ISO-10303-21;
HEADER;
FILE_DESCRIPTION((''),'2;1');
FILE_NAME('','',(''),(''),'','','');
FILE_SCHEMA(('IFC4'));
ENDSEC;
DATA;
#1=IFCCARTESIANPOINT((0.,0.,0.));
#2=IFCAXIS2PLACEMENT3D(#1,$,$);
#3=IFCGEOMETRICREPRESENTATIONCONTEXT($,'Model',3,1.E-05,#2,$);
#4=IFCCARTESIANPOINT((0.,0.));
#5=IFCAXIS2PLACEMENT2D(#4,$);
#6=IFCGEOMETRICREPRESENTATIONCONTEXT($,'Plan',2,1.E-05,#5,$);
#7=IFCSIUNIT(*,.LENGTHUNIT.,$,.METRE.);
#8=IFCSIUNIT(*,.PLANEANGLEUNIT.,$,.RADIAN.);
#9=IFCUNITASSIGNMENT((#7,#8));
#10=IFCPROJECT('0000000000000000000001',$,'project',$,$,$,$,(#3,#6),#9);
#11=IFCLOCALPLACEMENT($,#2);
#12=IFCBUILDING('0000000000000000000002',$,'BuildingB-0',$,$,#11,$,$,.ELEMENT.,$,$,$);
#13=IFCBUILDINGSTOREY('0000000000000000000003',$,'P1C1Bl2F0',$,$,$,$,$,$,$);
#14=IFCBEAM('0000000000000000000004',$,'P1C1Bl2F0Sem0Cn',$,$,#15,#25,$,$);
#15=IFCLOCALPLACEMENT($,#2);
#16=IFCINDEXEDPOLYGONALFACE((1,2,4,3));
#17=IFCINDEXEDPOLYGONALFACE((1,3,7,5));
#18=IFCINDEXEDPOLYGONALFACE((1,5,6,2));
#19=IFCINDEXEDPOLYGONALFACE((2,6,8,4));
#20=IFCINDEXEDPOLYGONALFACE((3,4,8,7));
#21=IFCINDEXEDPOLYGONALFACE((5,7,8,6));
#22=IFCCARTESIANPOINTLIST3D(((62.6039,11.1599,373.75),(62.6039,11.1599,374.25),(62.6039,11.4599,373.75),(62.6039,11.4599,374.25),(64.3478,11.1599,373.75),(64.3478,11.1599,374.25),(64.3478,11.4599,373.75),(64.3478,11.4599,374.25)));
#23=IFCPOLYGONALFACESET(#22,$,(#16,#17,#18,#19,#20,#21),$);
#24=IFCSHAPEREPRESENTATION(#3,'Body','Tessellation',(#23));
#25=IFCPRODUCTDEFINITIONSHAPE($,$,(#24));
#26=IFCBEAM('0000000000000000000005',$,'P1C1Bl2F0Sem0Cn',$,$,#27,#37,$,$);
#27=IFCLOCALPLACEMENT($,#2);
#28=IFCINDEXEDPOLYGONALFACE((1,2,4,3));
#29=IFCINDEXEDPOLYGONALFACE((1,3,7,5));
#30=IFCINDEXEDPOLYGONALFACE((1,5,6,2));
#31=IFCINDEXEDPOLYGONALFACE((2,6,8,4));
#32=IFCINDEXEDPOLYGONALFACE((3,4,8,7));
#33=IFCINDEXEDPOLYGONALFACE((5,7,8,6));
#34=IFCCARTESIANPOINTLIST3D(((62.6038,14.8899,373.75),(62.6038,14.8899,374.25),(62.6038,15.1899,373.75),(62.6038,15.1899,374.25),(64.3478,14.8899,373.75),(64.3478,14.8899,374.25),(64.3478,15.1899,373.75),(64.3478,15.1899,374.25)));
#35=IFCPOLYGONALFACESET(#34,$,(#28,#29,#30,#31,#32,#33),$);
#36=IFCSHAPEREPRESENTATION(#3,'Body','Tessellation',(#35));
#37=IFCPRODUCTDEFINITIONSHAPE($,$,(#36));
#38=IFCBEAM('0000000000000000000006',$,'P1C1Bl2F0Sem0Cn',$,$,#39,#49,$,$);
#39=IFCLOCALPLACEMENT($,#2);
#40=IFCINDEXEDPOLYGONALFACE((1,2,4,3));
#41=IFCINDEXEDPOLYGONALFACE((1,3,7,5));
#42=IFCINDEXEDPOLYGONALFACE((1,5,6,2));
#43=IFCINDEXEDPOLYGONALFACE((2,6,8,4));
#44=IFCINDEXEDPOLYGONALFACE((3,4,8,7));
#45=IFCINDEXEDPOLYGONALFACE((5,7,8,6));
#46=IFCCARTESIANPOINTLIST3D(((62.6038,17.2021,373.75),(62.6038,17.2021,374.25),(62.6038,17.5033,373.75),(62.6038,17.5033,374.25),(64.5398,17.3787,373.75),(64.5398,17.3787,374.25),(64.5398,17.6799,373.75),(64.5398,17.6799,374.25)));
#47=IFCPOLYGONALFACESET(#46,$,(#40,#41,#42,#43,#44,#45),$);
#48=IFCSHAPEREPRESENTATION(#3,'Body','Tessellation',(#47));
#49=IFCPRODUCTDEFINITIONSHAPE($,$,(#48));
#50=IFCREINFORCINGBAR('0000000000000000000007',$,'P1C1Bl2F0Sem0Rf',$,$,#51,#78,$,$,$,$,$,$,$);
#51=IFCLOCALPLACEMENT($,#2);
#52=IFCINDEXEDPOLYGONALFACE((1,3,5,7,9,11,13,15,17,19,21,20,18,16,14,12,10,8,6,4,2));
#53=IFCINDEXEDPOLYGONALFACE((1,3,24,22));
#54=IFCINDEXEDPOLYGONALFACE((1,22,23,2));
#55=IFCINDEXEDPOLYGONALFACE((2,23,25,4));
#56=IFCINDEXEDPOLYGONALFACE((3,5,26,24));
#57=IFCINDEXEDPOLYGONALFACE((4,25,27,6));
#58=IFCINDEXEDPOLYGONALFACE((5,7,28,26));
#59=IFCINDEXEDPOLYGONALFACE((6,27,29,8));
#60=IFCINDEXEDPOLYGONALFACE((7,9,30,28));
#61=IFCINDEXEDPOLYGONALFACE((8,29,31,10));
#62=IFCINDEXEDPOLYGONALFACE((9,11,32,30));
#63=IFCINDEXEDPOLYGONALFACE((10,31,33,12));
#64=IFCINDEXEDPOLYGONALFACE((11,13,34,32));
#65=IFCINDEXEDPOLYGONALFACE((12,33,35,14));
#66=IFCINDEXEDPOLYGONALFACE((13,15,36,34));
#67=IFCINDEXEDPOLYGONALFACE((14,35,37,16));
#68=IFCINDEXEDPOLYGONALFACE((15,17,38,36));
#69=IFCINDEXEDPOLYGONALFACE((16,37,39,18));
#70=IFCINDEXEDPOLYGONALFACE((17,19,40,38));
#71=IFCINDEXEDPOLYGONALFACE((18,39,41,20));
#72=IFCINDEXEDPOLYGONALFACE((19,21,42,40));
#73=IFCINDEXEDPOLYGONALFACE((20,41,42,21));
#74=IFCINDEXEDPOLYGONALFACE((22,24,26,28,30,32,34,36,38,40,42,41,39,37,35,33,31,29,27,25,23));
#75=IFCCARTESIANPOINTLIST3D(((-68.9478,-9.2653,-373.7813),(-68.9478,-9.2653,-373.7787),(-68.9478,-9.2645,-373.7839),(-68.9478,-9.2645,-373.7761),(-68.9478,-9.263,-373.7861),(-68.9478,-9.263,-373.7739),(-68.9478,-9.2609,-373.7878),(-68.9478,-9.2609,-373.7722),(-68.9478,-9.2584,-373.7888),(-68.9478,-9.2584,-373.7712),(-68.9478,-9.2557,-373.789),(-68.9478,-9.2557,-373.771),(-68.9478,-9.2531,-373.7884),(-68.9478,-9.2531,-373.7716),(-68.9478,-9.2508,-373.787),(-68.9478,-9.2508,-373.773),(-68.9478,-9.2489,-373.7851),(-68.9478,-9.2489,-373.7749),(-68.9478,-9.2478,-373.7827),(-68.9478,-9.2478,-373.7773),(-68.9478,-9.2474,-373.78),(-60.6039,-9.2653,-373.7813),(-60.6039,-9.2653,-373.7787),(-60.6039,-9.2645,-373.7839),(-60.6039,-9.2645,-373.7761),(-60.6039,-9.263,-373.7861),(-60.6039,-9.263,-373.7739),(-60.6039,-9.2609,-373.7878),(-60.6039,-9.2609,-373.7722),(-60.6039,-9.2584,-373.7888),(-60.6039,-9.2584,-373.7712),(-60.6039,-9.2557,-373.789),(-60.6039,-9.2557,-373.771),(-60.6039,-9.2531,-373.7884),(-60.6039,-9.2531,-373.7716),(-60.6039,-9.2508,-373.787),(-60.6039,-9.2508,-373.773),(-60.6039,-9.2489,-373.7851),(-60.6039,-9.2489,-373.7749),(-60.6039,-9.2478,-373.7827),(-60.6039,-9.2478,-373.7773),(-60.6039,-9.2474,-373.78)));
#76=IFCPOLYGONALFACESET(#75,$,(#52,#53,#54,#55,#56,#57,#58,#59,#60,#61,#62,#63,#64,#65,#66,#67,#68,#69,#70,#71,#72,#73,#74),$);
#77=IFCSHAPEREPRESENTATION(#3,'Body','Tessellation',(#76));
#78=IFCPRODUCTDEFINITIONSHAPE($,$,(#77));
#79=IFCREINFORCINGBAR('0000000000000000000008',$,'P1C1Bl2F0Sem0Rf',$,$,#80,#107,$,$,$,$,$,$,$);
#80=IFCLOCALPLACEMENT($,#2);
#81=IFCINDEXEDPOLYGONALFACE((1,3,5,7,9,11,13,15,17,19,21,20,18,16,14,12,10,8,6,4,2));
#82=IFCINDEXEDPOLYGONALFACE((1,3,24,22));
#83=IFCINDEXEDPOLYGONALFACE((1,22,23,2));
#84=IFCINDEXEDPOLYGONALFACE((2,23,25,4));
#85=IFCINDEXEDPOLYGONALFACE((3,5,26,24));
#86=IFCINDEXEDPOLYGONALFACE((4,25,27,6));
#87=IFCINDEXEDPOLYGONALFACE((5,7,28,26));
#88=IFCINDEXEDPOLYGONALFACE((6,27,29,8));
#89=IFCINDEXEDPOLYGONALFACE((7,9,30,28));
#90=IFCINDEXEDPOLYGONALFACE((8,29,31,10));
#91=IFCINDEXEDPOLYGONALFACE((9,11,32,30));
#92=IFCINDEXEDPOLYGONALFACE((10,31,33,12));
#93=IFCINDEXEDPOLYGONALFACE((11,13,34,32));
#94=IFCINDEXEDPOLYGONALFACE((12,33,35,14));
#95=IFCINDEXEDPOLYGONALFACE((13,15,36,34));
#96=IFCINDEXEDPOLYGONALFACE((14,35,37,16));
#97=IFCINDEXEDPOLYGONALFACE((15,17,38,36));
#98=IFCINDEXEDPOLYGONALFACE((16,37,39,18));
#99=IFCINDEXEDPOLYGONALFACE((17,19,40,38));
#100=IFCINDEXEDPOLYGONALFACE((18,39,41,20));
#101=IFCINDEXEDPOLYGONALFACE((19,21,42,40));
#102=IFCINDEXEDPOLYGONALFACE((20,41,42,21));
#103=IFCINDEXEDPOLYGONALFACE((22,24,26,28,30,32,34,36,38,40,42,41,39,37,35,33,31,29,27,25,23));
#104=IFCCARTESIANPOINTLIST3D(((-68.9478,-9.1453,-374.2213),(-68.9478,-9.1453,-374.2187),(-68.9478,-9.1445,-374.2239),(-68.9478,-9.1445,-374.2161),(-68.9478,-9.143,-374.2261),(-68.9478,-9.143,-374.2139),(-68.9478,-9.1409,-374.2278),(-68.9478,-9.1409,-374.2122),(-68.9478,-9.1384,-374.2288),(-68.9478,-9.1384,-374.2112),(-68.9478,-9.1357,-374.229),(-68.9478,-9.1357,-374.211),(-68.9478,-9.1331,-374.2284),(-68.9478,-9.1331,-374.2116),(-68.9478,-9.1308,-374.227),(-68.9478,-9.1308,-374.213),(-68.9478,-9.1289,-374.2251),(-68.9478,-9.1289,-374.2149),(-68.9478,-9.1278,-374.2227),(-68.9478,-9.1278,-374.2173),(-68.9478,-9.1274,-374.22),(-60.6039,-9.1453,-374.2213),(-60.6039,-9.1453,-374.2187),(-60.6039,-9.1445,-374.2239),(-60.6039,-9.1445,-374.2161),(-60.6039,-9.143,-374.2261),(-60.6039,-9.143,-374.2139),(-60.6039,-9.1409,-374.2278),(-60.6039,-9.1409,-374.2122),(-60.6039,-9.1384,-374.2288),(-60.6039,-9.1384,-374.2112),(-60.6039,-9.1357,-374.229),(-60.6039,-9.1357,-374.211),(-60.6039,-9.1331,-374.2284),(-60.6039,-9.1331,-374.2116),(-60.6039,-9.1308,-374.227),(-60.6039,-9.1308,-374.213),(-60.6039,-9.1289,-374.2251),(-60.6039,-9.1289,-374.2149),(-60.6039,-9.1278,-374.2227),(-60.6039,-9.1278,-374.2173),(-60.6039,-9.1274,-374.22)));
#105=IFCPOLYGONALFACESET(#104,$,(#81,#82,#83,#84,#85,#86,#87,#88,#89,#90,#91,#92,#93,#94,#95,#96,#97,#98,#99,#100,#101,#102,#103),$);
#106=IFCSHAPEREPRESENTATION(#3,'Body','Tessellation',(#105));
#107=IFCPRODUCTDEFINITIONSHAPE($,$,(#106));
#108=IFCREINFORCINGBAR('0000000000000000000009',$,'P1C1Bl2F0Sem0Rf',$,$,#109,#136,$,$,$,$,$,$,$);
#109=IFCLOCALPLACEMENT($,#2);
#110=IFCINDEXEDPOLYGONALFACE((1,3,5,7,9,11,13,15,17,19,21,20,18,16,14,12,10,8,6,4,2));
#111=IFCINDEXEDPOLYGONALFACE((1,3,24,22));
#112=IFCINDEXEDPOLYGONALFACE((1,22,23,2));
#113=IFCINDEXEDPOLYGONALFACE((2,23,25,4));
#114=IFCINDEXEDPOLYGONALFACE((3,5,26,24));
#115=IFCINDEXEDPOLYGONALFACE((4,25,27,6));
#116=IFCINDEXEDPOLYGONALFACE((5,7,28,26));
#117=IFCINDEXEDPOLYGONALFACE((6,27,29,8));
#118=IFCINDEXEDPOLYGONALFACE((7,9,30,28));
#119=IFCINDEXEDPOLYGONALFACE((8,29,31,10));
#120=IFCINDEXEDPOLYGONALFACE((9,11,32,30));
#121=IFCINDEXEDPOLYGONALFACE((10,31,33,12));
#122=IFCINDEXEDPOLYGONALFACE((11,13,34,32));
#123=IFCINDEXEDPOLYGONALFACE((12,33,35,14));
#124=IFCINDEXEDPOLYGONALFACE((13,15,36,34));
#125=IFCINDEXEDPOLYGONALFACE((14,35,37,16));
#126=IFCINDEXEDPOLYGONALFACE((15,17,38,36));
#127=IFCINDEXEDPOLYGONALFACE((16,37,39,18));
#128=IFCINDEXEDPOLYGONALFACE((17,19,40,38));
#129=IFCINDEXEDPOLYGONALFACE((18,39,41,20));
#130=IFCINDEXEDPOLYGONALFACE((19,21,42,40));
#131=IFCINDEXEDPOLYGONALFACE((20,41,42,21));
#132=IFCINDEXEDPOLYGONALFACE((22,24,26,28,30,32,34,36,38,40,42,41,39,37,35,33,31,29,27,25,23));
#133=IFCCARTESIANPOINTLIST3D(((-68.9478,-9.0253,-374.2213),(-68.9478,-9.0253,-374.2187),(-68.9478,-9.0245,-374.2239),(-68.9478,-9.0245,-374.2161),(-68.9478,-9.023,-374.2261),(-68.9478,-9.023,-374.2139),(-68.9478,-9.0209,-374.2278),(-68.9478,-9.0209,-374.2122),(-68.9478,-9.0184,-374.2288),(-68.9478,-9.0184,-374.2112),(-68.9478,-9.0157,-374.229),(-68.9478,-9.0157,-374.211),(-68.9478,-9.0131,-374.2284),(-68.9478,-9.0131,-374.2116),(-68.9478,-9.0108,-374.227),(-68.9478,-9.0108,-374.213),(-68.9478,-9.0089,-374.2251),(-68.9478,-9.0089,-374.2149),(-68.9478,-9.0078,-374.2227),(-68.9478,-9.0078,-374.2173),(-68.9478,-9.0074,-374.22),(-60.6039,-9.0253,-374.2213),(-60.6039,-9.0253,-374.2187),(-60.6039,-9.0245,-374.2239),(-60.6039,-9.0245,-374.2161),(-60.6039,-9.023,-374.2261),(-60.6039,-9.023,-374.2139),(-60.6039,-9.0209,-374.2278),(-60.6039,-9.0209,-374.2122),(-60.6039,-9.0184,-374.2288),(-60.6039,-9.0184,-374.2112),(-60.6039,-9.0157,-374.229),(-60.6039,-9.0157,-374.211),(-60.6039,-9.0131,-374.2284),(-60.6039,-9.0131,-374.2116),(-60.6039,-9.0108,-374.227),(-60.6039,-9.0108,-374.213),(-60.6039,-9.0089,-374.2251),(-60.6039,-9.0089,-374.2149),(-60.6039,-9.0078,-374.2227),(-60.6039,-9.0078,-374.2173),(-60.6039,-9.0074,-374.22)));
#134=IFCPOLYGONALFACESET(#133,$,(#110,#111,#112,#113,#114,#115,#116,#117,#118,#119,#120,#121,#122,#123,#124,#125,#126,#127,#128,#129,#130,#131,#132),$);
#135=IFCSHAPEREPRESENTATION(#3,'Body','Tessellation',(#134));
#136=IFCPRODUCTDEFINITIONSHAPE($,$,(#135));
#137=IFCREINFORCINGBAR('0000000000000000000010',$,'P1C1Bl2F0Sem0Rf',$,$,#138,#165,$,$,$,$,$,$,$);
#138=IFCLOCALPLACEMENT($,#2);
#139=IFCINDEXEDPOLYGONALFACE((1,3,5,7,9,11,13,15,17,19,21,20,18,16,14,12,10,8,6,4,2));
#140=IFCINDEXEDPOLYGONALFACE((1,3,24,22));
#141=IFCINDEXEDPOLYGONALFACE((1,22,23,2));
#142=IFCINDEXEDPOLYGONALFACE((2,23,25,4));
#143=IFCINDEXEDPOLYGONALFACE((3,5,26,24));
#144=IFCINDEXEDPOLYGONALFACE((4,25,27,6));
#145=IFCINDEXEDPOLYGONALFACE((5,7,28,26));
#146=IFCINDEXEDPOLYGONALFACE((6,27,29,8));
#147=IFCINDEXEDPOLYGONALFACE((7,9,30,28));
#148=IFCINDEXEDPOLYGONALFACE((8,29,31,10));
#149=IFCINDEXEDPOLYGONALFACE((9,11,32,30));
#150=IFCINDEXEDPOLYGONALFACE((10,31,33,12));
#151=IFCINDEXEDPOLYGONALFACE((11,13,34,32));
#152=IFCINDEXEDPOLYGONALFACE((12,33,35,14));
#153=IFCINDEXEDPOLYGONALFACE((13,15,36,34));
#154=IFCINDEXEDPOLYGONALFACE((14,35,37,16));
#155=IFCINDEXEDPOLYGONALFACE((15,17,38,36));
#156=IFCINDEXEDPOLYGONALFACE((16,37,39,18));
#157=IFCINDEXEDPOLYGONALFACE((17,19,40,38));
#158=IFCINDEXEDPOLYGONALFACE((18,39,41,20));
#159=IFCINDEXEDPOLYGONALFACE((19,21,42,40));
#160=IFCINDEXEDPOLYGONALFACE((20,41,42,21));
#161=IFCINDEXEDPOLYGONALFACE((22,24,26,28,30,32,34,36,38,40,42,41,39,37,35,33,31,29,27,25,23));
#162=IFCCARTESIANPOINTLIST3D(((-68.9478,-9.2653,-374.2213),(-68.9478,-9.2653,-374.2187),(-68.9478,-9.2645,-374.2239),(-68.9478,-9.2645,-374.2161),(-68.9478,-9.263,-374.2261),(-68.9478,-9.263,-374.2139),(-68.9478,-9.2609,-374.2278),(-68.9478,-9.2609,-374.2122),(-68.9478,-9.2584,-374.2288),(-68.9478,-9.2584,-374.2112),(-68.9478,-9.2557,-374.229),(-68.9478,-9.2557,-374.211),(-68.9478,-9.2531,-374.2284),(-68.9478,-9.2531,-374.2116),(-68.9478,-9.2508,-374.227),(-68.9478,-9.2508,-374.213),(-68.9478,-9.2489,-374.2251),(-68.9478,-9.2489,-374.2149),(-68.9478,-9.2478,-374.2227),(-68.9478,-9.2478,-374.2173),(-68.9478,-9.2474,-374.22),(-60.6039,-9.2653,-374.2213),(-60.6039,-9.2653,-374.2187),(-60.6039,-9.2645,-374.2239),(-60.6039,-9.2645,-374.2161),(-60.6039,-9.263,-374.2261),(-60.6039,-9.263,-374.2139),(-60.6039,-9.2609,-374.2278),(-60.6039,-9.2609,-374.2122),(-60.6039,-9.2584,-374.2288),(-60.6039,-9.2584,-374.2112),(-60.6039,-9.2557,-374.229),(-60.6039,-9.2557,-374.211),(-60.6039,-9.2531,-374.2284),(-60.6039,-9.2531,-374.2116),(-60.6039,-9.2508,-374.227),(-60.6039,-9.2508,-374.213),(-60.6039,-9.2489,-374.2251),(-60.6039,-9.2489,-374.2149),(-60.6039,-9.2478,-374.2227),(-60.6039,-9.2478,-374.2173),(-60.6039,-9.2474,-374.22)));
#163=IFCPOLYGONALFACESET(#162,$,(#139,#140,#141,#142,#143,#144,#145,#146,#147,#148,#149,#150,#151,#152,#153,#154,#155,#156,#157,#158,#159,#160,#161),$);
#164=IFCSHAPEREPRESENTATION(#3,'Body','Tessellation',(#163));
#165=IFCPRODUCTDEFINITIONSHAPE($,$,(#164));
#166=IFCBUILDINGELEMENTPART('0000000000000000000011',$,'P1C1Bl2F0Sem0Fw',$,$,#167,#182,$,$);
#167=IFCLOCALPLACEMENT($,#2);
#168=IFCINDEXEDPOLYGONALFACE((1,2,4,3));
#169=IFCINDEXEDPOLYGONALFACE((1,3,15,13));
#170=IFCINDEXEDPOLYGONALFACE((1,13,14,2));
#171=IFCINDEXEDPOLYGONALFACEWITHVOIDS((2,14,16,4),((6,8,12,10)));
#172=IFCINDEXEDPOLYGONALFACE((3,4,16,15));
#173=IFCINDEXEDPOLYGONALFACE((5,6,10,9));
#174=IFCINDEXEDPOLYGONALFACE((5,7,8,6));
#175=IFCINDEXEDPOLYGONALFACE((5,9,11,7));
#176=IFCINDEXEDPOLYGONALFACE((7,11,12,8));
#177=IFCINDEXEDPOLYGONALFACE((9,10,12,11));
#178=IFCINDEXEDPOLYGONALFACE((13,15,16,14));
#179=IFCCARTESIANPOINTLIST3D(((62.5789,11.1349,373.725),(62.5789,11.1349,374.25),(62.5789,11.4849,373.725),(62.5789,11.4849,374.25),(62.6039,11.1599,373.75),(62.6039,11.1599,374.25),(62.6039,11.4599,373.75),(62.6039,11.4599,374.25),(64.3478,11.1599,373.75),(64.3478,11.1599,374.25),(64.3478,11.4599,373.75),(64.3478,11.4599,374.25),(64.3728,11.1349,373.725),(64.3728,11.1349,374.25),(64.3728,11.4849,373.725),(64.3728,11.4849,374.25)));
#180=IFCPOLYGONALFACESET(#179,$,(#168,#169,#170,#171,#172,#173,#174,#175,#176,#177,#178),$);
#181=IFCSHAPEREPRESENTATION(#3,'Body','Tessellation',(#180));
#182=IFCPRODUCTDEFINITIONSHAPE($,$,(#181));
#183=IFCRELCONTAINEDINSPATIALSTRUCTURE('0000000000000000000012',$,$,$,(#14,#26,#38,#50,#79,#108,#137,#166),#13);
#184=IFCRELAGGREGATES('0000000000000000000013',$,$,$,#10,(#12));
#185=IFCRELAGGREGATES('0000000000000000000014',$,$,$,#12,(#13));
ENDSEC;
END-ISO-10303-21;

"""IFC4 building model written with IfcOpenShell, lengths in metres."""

from ifc_helpers import new_model, entity, si_unit, origin, origin_2d, place, context, project, spatial, polyline, outline, extrude, element, save


model = new_model("IFC4")

# Units and contexts
model_context = context("Model", 3, precision=1e-05, world=origin())
plan_context = context("Plan", 2, precision=1e-05, world=origin_2d())
ifc_project = project(units=[si_unit("LENGTHUNIT", "METRE"), si_unit("PLANEANGLEUNIT", "RADIAN")], contexts=[model_context, plan_context])

# Building, storey
building_placement = place(None, origin())
building = spatial("IfcBuilding", under=ifc_project, at=building_placement, Name="BuildingB-0", CompositionType="ELEMENT")
storey = spatial("IfcBuildingStorey", under=building, Name="P1C1Bl2F0")

# Beams
element("IfcBeam", 1, inside=storey, Name="P1C1Bl2F0Sem0Cn", context=model_context, shape_type="SweptSolid", body=[
    extrude(outline(polyline([(64.3478, 11.1599, 373.75), (64.3478, 11.4599, 373.75), (62.6039, 11.4599, 373.75), (62.6039, 11.1599, 373.75), (64.3478, 11.1599, 373.75)])), None, (0.0, 0.0, 1.0), 0.5),
])
element("IfcBeam", 2, inside=storey, Name="P1C1Bl2F0Sem0Cn", context=model_context, shape_type="SweptSolid", body=[
    extrude(outline(polyline([(64.3478, 14.8899, 373.75), (64.3478, 15.1899, 373.75), (62.6038, 15.1899, 373.75), (62.6038, 14.8899, 373.75), (64.3478, 14.8899, 373.75)])), None, (0.0, 0.0, 1.0), 0.5),
])
element("IfcBeam", 3, inside=storey, Name="P1C1Bl2F0Sem0Cn", context=model_context, shape_type="SweptSolid", body=[
    extrude(outline(polyline([(64.5398, 17.3787, 373.75), (64.5398, 17.6799, 373.75), (62.6038, 17.5033, 373.75), (62.6038, 17.2021, 373.75), (64.5398, 17.3787, 373.75)])), None, (0.0, 0.0, 1.0), 0.5),
])

# Reinforcing bars
element("IfcReinforcingBar", 4, inside=storey, Name="P1C1Bl2F0Sem0Rf", context=model_context, shape_type="SweptSolid", body=[
    entity("IfcSurfaceCurveSweptAreaSolid", entity("IfcCircleProfileDef", "AREA", None, None, 0.009), None, entity("IfcPolyline", [entity("IfcCartesianPoint", [60.6039, 9.2564, 373.78]), entity("IfcCartesianPoint", [68.9478, 9.2564, 373.78])]), None, None, entity("IfcPlane", entity("IfcAxis2Placement3D", entity("IfcCartesianPoint", [60.6039, 9.2564, 373.78]), entity("IfcDirection", [0.0, 0.0, 1.0]), entity("IfcDirection", [1.0, 0.0, 0.0])))),
])
element("IfcReinforcingBar", 5, inside=storey, Name="P1C1Bl2F0Sem0Rf", context=model_context, shape_type="SweptSolid", body=[
    entity("IfcSurfaceCurveSweptAreaSolid", entity("IfcCircleProfileDef", "AREA", None, None, 0.009), None, entity("IfcPolyline", [entity("IfcCartesianPoint", [60.6039, 9.1364, 374.22]), entity("IfcCartesianPoint", [68.9478, 9.1364, 374.22])]), None, None, entity("IfcPlane", entity("IfcAxis2Placement3D", entity("IfcCartesianPoint", [60.6039, 9.1364, 374.22]), entity("IfcDirection", [0.0, 0.0, 1.0]), entity("IfcDirection", [1.0, 0.0, 0.0])))),
])
element("IfcReinforcingBar", 6, inside=storey, Name="P1C1Bl2F0Sem0Rf", context=model_context, shape_type="SweptSolid", body=[
    entity("IfcSurfaceCurveSweptAreaSolid", entity("IfcCircleProfileDef", "AREA", None, None, 0.009), None, entity("IfcPolyline", [entity("IfcCartesianPoint", [60.6039, 9.0164, 374.22]), entity("IfcCartesianPoint", [68.9478, 9.0164, 374.22])]), None, None, entity("IfcPlane", entity("IfcAxis2Placement3D", entity("IfcCartesianPoint", [60.6039, 9.0164, 374.22]), entity("IfcDirection", [0.0, 0.0, 1.0]), entity("IfcDirection", [1.0, 0.0, 0.0])))),
])
element("IfcReinforcingBar", 7, inside=storey, Name="P1C1Bl2F0Sem0Rf", context=model_context, shape_type="SweptSolid", body=[
    entity("IfcSurfaceCurveSweptAreaSolid", entity("IfcCircleProfileDef", "AREA", None, None, 0.009), None, entity("IfcPolyline", [entity("IfcCartesianPoint", [60.6039, 9.2564, 374.22]), entity("IfcCartesianPoint", [68.9478, 9.2564, 374.22])]), None, None, entity("IfcPlane", entity("IfcAxis2Placement3D", entity("IfcCartesianPoint", [60.6039, 9.2564, 374.22]), entity("IfcDirection", [0.0, 0.0, 1.0]), entity("IfcDirection", [1.0, 0.0, 0.0])))),
])

# Building element part, opening
building_element_part_1 = element("IfcBuildingElementPart", 8, inside=storey, Name="P1C1Bl2F0Sem0Fw", context=model_context, shape_type="SweptSolid", body=[
    extrude(outline(polyline([(64.3728, 11.1349, 373.725), (64.3728, 11.4849, 373.725), (62.5789, 11.4849, 373.725), (62.5789, 11.1349, 373.725), (64.3728, 11.1349, 373.725)])), None, (0.0, 0.0, 1.0), 0.525),
])
element("IfcOpeningElement", 9, inside=storey, cuts=building_element_part_1, context=model_context, shape_type="SweptSolid", body=[
    extrude(outline(polyline([(64.3478, 11.1599, 373.75), (64.3478, 11.4599, 373.75), (62.6039, 11.4599, 373.75), (62.6039, 11.1599, 373.75), (64.3478, 11.1599, 373.75)])), None, (0.0, 0.0, 1.0), 0.5),
])

save(model, "model.ifc")
